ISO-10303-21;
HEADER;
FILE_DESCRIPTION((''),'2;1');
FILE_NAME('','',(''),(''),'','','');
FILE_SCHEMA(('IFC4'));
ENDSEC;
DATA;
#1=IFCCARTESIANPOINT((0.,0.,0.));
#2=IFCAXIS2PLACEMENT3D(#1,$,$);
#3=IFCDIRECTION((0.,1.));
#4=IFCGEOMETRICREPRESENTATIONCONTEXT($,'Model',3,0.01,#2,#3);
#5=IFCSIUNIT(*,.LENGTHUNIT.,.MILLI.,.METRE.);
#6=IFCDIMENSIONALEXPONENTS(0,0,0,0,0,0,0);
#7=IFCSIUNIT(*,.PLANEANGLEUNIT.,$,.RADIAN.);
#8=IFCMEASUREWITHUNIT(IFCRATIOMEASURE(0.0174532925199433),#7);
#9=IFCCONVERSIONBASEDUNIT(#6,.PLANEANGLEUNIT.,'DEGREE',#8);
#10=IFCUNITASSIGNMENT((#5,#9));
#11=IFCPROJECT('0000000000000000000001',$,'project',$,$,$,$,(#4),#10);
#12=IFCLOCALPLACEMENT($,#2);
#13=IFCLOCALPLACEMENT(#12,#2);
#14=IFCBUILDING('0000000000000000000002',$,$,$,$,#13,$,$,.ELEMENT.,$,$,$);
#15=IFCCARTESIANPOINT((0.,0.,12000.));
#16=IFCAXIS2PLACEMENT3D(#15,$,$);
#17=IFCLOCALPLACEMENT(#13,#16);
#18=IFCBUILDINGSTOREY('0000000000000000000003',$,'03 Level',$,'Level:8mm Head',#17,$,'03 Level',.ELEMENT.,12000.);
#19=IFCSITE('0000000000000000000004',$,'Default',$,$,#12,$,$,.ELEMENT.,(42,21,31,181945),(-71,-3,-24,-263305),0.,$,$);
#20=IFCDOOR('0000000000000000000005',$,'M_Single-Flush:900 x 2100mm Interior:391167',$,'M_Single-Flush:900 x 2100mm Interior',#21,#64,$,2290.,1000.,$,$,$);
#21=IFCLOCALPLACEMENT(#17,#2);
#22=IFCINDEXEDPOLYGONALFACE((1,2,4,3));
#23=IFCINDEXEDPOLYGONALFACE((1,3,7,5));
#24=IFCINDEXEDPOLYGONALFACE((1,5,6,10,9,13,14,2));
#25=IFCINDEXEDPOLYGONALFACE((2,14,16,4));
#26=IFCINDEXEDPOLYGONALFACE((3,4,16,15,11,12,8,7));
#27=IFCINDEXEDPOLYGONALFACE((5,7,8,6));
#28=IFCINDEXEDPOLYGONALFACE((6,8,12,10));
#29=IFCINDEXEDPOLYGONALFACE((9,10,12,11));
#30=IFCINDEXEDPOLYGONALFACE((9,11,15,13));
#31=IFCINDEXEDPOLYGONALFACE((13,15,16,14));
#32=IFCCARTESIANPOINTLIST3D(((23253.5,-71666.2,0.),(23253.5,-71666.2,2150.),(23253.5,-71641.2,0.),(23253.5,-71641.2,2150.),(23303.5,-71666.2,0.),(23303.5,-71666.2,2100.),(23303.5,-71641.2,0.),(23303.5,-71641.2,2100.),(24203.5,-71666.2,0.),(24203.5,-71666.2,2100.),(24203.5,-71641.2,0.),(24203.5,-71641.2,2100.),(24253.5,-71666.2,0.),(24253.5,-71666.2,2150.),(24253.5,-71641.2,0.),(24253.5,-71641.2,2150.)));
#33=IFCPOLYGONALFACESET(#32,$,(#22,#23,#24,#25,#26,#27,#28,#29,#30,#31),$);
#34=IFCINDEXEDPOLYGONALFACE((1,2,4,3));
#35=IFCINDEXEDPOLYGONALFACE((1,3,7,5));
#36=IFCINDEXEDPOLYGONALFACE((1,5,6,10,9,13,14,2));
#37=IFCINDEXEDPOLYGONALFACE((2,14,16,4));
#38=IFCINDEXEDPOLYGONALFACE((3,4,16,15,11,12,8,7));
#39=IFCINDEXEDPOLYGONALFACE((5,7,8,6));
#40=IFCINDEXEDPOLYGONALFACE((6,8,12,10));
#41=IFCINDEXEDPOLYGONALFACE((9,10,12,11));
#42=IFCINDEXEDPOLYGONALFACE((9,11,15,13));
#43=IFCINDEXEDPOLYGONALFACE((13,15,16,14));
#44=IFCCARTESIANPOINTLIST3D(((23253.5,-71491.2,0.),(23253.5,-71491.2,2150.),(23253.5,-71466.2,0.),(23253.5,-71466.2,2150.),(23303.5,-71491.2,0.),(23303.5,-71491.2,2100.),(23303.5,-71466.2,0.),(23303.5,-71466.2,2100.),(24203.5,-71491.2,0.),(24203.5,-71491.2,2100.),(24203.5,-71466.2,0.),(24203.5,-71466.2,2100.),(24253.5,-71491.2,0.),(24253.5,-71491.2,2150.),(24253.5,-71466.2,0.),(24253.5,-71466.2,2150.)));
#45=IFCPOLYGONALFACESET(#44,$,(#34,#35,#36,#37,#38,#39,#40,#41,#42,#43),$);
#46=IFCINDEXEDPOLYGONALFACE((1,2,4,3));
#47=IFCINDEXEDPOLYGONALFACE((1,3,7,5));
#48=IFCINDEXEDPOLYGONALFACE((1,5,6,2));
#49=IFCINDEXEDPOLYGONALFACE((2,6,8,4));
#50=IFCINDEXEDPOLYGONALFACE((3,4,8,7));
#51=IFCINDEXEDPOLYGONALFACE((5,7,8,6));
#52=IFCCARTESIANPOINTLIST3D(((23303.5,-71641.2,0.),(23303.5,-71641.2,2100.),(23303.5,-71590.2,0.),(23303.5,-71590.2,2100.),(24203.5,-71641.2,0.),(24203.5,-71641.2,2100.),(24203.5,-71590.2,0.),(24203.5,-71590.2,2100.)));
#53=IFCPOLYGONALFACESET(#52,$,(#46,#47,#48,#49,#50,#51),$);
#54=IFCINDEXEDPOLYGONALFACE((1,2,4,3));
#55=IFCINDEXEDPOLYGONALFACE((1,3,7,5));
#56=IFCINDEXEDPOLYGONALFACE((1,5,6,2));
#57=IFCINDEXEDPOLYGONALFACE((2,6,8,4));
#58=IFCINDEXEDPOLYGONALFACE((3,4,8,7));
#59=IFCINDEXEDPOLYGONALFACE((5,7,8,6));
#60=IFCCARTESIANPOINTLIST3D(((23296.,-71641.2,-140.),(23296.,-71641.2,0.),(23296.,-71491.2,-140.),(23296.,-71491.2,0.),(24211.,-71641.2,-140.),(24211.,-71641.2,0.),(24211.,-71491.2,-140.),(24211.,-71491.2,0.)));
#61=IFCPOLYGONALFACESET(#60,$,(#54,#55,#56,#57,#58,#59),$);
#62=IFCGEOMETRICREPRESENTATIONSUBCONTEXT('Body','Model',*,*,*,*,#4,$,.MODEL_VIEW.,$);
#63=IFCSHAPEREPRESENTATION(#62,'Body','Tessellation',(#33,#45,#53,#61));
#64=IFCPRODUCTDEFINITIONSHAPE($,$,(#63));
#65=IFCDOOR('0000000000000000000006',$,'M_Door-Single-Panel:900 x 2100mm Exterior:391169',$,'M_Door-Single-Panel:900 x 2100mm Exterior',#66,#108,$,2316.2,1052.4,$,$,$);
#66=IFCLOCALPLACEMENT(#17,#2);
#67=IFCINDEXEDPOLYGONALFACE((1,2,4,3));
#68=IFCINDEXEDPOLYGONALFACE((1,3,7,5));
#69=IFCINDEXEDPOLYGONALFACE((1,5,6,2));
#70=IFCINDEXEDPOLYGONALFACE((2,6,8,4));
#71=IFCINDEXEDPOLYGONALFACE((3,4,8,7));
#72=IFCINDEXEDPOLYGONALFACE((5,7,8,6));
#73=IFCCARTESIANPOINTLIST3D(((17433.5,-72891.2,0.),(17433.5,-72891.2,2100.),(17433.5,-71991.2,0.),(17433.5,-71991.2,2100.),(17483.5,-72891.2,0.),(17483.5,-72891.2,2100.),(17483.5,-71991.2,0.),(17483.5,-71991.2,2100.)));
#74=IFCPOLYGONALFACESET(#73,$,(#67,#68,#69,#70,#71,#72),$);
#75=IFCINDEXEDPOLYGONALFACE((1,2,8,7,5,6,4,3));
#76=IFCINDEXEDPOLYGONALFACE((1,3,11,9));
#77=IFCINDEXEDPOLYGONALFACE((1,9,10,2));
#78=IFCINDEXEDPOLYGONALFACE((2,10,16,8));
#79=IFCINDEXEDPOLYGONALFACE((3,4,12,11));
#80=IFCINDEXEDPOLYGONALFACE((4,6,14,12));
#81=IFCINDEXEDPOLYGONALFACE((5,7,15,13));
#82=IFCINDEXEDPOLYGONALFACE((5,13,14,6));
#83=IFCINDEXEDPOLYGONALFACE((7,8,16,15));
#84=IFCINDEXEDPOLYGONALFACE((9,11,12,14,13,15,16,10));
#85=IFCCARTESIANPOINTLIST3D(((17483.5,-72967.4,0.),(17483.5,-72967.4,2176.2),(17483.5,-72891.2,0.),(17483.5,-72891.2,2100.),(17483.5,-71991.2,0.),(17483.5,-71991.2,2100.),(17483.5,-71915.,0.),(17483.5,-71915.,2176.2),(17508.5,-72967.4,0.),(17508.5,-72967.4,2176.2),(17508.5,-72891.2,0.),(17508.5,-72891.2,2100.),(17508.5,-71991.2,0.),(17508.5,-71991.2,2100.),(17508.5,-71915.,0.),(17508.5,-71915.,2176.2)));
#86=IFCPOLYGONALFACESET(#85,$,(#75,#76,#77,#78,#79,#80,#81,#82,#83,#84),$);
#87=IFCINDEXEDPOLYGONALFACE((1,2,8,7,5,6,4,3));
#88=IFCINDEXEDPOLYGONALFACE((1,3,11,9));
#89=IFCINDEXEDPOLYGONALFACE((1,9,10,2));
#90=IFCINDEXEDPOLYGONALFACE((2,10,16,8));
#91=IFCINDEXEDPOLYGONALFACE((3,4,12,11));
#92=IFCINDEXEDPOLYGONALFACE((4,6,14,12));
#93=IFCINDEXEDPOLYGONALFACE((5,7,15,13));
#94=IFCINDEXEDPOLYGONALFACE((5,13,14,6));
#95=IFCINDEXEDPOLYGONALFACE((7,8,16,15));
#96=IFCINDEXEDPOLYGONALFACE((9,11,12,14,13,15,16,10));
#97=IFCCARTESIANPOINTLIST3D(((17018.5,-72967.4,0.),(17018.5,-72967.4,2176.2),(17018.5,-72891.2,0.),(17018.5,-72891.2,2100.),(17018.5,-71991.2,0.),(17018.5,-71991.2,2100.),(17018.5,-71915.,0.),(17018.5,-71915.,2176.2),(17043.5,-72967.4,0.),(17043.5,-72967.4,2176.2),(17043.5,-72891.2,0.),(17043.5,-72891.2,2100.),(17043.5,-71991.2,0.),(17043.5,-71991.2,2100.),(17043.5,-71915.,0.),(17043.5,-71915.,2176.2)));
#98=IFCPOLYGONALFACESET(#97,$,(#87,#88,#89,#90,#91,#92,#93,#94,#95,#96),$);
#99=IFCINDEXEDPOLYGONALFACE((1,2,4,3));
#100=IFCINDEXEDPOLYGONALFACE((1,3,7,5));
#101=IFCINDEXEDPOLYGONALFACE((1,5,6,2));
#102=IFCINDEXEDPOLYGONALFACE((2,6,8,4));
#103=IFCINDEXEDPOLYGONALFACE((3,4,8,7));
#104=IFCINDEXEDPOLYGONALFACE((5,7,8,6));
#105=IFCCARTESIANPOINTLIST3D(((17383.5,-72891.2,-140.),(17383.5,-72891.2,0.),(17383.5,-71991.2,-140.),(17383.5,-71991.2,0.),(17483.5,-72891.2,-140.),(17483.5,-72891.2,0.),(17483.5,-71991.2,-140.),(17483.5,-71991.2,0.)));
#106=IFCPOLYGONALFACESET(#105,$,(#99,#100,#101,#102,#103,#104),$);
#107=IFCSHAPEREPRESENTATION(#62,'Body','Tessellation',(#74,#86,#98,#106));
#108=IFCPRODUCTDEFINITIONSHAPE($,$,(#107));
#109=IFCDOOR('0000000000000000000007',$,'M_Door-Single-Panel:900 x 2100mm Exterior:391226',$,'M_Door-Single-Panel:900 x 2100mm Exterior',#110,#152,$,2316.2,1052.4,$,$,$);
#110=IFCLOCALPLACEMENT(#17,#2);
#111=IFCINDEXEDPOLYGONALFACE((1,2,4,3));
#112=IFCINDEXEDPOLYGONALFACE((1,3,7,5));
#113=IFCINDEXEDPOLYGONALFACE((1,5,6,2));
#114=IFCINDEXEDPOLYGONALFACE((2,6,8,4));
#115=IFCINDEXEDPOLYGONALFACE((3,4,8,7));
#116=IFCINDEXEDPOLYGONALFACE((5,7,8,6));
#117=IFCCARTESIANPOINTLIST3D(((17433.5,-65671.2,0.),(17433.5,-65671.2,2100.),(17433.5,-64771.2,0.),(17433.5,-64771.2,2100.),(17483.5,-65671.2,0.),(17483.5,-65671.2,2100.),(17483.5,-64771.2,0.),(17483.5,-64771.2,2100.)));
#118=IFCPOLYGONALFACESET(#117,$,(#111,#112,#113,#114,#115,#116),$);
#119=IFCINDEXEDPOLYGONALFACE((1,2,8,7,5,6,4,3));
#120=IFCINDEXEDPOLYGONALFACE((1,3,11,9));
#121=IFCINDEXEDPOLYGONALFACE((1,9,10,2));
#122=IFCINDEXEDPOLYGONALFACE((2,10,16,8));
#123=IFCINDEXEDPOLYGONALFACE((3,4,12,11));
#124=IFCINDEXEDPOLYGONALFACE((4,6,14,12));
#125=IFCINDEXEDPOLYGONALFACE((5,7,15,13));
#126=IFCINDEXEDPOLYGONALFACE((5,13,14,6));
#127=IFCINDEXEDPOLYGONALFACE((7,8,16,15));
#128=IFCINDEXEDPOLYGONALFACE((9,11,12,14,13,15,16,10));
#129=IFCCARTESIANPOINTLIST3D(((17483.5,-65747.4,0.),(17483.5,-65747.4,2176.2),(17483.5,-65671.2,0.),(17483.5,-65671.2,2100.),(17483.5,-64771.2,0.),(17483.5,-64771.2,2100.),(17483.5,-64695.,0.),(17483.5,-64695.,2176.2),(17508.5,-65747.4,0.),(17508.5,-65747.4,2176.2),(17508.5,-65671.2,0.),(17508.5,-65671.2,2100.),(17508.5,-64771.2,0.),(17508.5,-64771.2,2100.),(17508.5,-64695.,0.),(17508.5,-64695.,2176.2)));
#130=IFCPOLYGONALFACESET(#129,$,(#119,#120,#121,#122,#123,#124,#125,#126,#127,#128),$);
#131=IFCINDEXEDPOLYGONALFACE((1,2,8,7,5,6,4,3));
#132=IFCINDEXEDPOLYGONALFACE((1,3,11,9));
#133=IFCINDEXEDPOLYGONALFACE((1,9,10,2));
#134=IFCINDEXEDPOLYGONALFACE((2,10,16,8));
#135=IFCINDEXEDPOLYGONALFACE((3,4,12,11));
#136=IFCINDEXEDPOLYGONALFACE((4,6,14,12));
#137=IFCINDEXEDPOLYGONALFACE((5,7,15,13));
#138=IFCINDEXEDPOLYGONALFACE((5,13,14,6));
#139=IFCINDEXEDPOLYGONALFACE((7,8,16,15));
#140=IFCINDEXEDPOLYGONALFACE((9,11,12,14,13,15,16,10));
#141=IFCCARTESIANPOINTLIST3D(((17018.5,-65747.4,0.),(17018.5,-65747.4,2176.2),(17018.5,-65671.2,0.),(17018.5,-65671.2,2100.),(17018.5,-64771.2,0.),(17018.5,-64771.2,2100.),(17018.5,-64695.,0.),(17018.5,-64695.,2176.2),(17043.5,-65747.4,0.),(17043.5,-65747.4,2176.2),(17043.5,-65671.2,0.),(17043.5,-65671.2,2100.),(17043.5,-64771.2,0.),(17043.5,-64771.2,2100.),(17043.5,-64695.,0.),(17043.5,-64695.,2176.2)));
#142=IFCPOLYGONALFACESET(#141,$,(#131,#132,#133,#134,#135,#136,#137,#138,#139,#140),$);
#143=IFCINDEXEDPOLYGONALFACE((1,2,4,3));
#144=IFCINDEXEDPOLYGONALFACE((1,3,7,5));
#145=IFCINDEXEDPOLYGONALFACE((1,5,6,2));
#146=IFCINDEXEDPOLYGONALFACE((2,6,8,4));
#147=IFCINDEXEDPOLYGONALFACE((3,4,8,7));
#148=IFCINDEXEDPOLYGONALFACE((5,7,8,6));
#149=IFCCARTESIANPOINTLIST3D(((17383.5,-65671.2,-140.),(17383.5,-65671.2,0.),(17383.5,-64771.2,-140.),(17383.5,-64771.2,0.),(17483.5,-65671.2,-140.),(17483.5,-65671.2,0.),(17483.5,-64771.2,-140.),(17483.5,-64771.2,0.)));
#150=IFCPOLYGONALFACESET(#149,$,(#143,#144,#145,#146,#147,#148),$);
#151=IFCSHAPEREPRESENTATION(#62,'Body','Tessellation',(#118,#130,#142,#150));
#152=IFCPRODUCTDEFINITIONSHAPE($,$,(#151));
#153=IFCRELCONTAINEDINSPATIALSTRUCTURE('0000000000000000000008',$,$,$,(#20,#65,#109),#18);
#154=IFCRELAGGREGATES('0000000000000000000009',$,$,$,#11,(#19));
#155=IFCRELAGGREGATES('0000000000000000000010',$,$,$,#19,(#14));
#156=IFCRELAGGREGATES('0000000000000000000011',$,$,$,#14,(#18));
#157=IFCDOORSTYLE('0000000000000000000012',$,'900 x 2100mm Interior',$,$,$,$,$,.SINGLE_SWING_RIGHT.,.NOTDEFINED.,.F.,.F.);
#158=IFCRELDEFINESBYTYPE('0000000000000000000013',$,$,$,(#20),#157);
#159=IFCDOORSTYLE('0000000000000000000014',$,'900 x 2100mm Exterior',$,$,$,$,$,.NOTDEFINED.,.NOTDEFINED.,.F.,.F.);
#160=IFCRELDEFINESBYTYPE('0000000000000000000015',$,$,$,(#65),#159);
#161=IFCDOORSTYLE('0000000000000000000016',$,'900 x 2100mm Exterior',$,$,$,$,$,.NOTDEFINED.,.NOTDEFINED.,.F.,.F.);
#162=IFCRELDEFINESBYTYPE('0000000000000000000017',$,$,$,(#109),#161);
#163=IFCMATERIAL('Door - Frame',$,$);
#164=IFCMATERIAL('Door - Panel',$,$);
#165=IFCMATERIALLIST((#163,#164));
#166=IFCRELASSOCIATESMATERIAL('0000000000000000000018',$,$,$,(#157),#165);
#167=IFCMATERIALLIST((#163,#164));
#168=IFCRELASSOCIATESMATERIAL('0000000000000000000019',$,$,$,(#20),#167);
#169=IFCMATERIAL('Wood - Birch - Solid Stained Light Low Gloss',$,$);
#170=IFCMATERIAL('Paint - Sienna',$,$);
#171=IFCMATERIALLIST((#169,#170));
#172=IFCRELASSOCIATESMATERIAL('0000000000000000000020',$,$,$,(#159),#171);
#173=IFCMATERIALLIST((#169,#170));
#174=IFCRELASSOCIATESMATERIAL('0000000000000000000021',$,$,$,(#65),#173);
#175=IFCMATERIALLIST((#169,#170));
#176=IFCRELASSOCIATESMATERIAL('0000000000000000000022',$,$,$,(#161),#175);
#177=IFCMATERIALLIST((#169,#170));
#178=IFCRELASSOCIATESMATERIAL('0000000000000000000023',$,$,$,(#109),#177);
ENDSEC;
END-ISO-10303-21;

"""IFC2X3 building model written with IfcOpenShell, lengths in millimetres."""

from ifc_helpers import new_model, entity, si_unit, converted_unit, direction, frame, frame_2d, origin, origin_2d_with_axis, place, context, subcontext, project, spatial, polyline, rectangle, outline, extrude, source, transform, mapped, material, material_list, type_object, type_shapes, element, save


model = new_model("IFC2X3")

# Units and contexts
model_context = context("Model", 3, precision=0.01, world=origin(), true_north=direction((0.0, 1.0)))
body_context = subcontext(model_context, "Body", "Model", "MODEL_VIEW")
ifc_project = project(units=[si_unit("LENGTHUNIT", "METRE", prefix="MILLI"), converted_unit("PLANEANGLEUNIT", "DEGREE", entity("IfcRatioMeasure", 0.0174532925199433), si_unit("PLANEANGLEUNIT", "RADIAN"), dimensions=[0, 0, 0, 0, 0, 0, 0])], contexts=[model_context])

# Site, building, storey
site_placement = place(None, origin())
site = spatial("IfcSite", under=ifc_project, at=site_placement, Name="Default", CompositionType="ELEMENT", RefLatitude=(42, 21, 31, 181945), RefLongitude=(-71, -3, -24, -263305), RefElevation=0.0)
building_placement = place(site_placement, origin())
building = spatial("IfcBuilding", under=site, at=building_placement, CompositionType="ELEMENT")
storey_placement = place(building_placement, frame((0.0, 0.0, 12000.0)))
storey = spatial("IfcBuildingStorey", under=building, at=storey_placement, Name="03 Level", ObjectType="Level:8mm Head", LongName="03 Level", CompositionType="ELEMENT", Elevation=12000.0)

# Doors
ifc_material_1 = material(Name="Door - Frame")
ifc_material_2 = material(Name="Door - Panel")
ifc_material_list_1 = material_list([ifc_material_1, ifc_material_2])
ifc_material_list_2 = material_list([ifc_material_1, ifc_material_2])
door_style_1 = type_object("IfcDoorStyle", Name="900 x 2100mm Interior", ConstructionType="NOTDEFINED", OperationType="SINGLE_SWING_RIGHT", ParameterTakesPrecedence=False, Sizeable=False, material=ifc_material_list_2)
shared_shape_1 = source(origin(), body_context, "Body", "SweptSolid", [
    extrude(outline(polyline([(-500.0, -1087.5), (500.0, -1087.5), (500.0, 1062.5), (450.0, 1062.5), (450.0, -1037.5), (-450.0, -1037.5), (-450.0, 1062.5), (-500.0, 1062.5), (-500.0, -1087.5)])), frame((450.0, 150.0, 1202.5), z_axis=(0.0, 1.0, 0.0), x_axis=(1.0, 0.0, 0.0)), (0.0, 0.0, 1.0), 25.0),
    extrude(outline(polyline([(-1087.5, -500.0), (1062.5, -500.0), (1062.5, -450.0), (-1037.5, -450.0), (-1037.5, 450.0), (1062.5, 450.0), (1062.5, 500.0), (-1087.5, 500.0), (-1087.5, -500.0)])), frame((450.0, -25.0, 1202.5), z_axis=(0.0, 1.0, 0.0), x_axis=(0.0, 0.0, -1.0)), (0.0, 0.0, 1.0), 25.0),
    extrude(rectangle(XDim=51.0, YDim=900.0, at=frame_2d((0.0, 0.0), x_axis=(1.0, 0.0))), frame((450.0, 124.5, 140.0), z_axis=(0.0, 0.0, 1.0), x_axis=(0.0, 1.0, 0.0)), (0.0, 0.0, 1.0), 2100.0),
    extrude(rectangle(XDim=915.0, YDim=150.0, at=origin_2d_with_axis()), frame((450.0, 75.0, 0.0), z_axis=(0.0, 0.0, 1.0), x_axis=(-1.0, 0.0, 0.0)), (0.0, 0.0, 1.0), 140.0),
])
type_shapes(door_style_1, [shared_shape_1])
door_1_placement = place(storey_placement, frame((24203.5, -71491.2, -140.0), z_axis=(0.0, 0.0, 1.0), x_axis=(-1.0, 0.0, 0.0)))
element("IfcDoor", 1, at=door_1_placement, inside=storey, type_object=door_style_1, material=ifc_material_list_1, Name="M_Single-Flush:900 x 2100mm Interior:391167", ObjectType="M_Single-Flush:900 x 2100mm Interior", OverallHeight=2290.0, OverallWidth=1000.0, context=body_context, shape_type="MappedRepresentation", body=[
    mapped(shared_shape_1, transform((0.0, 0.0, 0.0), scale=1.0)),
])
ifc_material_3 = material(Name="Wood - Birch - Solid Stained Light Low Gloss")
ifc_material_4 = material(Name="Paint - Sienna")
ifc_material_list_3 = material_list([ifc_material_3, ifc_material_4])
ifc_material_list_4 = material_list([ifc_material_3, ifc_material_4])
door_style_2 = type_object("IfcDoorStyle", Name="900 x 2100mm Exterior", ConstructionType="NOTDEFINED", OperationType="NOTDEFINED", ParameterTakesPrecedence=False, Sizeable=False, material=ifc_material_list_4)
shared_shape_2 = source(origin(), body_context, "Body", "SweptSolid", [
    extrude(rectangle(XDim=50.0, YDim=900.0, at=origin_2d_with_axis()), frame((450.0, 415.0, 140.0), z_axis=(0.0, 0.0, 1.0), x_axis=(0.0, 1.0, 0.0)), (0.0, 0.0, 1.0), 2100.0),
    extrude(outline(polyline([(-526.2, -1107.2), (526.2, -1107.2), (526.2, 1069.0), (450.0, 1069.0), (450.0, -1031.0), (-450.0, -1031.0), (-450.0, 1069.0), (-526.2, 1069.0), (-526.2, -1107.2)])), frame((450.0, 440.0, 1209.0), z_axis=(0.0, 1.0, 0.0), x_axis=(1.0, 0.0, 0.0)), (0.0, 0.0, 1.0), 25.0),
    extrude(outline(polyline([(-1107.2, -526.2), (1069.0, -526.2), (1069.0, -450.0), (-1031.0, -450.0), (-1031.0, 450.0), (1069.0, 450.0), (1069.0, 526.2), (-1107.2, 526.2), (-1107.2, -526.2)])), frame((450.0, -25.0, 1209.0), z_axis=(0.0, 1.0, 0.0), x_axis=(0.0, 0.0, -1.0)), (0.0, 0.0, 1.0), 25.0),
    extrude(rectangle(XDim=900.0, YDim=100.0, at=origin_2d_with_axis()), frame((450.0, 390.0, 0.0), z_axis=(0.0, 0.0, 1.0), x_axis=(-1.0, 0.0, 0.0)), (0.0, 0.0, 1.0), 140.0),
])
type_shapes(door_style_2, [shared_shape_2])
door_2_placement = place(storey_placement, frame((17043.5, -71991.2, -140.0), z_axis=(0.0, 0.0, 1.0), x_axis=(0.0, -1.0, 0.0)))
element("IfcDoor", 2, at=door_2_placement, inside=storey, type_object=door_style_2, material=ifc_material_list_3, Name="M_Door-Single-Panel:900 x 2100mm Exterior:391169", ObjectType="M_Door-Single-Panel:900 x 2100mm Exterior", OverallHeight=2316.2, OverallWidth=1052.4, context=body_context, shape_type="MappedRepresentation", body=[
    mapped(shared_shape_2, transform((0.0, 0.0, 0.0), scale=1.0)),
])
ifc_material_list_5 = material_list([ifc_material_3, ifc_material_4])
ifc_material_list_6 = material_list([ifc_material_3, ifc_material_4])
door_style_3 = type_object("IfcDoorStyle", Name="900 x 2100mm Exterior", ConstructionType="NOTDEFINED", OperationType="NOTDEFINED", ParameterTakesPrecedence=False, Sizeable=False, material=ifc_material_list_6)
shared_shape_3 = source(origin(), body_context, "Body", "SweptSolid", [
    extrude(rectangle(XDim=900.0, YDim=50.0, at=origin_2d_with_axis()), frame((450.0, 415.0, 140.0)), (0.0, 0.0, 1.0), 2100.0),
    extrude(outline(polyline([(-526.2, -1107.2), (526.2, -1107.2), (526.2, 1069.0), (450.0, 1069.0), (450.0, -1031.0), (-450.0, -1031.0), (-450.0, 1069.0), (-526.2, 1069.0), (-526.2, -1107.2)])), frame((450.0, 465.0, 1209.0), z_axis=(0.0, -1.0, 0.0), x_axis=(-1.0, 0.0, 0.0)), (0.0, 0.0, 1.0), 25.0),
    extrude(outline(polyline([(-1107.2, -526.2), (1069.0, -526.2), (1069.0, -450.0), (-1031.0, -450.0), (-1031.0, 450.0), (1069.0, 450.0), (1069.0, 526.2), (-1107.2, 526.2), (-1107.2, -526.2)])), frame((450.0, 0.0, 1209.0), z_axis=(0.0, -1.0, 0.0), x_axis=(0.0, 0.0, -1.0)), (0.0, 0.0, 1.0), 25.0),
    extrude(rectangle(XDim=100.0, YDim=900.0, at=origin_2d_with_axis()), frame((450.0, 390.0, 0.0), z_axis=(0.0, 0.0, 1.0), x_axis=(0.0, -1.0, 0.0)), (0.0, 0.0, 1.0), 140.0),
])
type_shapes(door_style_3, [shared_shape_3])
door_3_placement = place(storey_placement, frame((17043.5, -64771.2, -140.0), z_axis=(0.0, 0.0, 1.0), x_axis=(0.0, -1.0, 0.0)))
element("IfcDoor", 3, at=door_3_placement, inside=storey, type_object=door_style_3, material=ifc_material_list_5, Name="M_Door-Single-Panel:900 x 2100mm Exterior:391226", ObjectType="M_Door-Single-Panel:900 x 2100mm Exterior", OverallHeight=2316.2, OverallWidth=1052.4, context=body_context, shape_type="MappedRepresentation", body=[
    mapped(shared_shape_3, transform((0.0, 0.0, 0.0), scale=1.0)),
])

save(model, "model.ifc")
